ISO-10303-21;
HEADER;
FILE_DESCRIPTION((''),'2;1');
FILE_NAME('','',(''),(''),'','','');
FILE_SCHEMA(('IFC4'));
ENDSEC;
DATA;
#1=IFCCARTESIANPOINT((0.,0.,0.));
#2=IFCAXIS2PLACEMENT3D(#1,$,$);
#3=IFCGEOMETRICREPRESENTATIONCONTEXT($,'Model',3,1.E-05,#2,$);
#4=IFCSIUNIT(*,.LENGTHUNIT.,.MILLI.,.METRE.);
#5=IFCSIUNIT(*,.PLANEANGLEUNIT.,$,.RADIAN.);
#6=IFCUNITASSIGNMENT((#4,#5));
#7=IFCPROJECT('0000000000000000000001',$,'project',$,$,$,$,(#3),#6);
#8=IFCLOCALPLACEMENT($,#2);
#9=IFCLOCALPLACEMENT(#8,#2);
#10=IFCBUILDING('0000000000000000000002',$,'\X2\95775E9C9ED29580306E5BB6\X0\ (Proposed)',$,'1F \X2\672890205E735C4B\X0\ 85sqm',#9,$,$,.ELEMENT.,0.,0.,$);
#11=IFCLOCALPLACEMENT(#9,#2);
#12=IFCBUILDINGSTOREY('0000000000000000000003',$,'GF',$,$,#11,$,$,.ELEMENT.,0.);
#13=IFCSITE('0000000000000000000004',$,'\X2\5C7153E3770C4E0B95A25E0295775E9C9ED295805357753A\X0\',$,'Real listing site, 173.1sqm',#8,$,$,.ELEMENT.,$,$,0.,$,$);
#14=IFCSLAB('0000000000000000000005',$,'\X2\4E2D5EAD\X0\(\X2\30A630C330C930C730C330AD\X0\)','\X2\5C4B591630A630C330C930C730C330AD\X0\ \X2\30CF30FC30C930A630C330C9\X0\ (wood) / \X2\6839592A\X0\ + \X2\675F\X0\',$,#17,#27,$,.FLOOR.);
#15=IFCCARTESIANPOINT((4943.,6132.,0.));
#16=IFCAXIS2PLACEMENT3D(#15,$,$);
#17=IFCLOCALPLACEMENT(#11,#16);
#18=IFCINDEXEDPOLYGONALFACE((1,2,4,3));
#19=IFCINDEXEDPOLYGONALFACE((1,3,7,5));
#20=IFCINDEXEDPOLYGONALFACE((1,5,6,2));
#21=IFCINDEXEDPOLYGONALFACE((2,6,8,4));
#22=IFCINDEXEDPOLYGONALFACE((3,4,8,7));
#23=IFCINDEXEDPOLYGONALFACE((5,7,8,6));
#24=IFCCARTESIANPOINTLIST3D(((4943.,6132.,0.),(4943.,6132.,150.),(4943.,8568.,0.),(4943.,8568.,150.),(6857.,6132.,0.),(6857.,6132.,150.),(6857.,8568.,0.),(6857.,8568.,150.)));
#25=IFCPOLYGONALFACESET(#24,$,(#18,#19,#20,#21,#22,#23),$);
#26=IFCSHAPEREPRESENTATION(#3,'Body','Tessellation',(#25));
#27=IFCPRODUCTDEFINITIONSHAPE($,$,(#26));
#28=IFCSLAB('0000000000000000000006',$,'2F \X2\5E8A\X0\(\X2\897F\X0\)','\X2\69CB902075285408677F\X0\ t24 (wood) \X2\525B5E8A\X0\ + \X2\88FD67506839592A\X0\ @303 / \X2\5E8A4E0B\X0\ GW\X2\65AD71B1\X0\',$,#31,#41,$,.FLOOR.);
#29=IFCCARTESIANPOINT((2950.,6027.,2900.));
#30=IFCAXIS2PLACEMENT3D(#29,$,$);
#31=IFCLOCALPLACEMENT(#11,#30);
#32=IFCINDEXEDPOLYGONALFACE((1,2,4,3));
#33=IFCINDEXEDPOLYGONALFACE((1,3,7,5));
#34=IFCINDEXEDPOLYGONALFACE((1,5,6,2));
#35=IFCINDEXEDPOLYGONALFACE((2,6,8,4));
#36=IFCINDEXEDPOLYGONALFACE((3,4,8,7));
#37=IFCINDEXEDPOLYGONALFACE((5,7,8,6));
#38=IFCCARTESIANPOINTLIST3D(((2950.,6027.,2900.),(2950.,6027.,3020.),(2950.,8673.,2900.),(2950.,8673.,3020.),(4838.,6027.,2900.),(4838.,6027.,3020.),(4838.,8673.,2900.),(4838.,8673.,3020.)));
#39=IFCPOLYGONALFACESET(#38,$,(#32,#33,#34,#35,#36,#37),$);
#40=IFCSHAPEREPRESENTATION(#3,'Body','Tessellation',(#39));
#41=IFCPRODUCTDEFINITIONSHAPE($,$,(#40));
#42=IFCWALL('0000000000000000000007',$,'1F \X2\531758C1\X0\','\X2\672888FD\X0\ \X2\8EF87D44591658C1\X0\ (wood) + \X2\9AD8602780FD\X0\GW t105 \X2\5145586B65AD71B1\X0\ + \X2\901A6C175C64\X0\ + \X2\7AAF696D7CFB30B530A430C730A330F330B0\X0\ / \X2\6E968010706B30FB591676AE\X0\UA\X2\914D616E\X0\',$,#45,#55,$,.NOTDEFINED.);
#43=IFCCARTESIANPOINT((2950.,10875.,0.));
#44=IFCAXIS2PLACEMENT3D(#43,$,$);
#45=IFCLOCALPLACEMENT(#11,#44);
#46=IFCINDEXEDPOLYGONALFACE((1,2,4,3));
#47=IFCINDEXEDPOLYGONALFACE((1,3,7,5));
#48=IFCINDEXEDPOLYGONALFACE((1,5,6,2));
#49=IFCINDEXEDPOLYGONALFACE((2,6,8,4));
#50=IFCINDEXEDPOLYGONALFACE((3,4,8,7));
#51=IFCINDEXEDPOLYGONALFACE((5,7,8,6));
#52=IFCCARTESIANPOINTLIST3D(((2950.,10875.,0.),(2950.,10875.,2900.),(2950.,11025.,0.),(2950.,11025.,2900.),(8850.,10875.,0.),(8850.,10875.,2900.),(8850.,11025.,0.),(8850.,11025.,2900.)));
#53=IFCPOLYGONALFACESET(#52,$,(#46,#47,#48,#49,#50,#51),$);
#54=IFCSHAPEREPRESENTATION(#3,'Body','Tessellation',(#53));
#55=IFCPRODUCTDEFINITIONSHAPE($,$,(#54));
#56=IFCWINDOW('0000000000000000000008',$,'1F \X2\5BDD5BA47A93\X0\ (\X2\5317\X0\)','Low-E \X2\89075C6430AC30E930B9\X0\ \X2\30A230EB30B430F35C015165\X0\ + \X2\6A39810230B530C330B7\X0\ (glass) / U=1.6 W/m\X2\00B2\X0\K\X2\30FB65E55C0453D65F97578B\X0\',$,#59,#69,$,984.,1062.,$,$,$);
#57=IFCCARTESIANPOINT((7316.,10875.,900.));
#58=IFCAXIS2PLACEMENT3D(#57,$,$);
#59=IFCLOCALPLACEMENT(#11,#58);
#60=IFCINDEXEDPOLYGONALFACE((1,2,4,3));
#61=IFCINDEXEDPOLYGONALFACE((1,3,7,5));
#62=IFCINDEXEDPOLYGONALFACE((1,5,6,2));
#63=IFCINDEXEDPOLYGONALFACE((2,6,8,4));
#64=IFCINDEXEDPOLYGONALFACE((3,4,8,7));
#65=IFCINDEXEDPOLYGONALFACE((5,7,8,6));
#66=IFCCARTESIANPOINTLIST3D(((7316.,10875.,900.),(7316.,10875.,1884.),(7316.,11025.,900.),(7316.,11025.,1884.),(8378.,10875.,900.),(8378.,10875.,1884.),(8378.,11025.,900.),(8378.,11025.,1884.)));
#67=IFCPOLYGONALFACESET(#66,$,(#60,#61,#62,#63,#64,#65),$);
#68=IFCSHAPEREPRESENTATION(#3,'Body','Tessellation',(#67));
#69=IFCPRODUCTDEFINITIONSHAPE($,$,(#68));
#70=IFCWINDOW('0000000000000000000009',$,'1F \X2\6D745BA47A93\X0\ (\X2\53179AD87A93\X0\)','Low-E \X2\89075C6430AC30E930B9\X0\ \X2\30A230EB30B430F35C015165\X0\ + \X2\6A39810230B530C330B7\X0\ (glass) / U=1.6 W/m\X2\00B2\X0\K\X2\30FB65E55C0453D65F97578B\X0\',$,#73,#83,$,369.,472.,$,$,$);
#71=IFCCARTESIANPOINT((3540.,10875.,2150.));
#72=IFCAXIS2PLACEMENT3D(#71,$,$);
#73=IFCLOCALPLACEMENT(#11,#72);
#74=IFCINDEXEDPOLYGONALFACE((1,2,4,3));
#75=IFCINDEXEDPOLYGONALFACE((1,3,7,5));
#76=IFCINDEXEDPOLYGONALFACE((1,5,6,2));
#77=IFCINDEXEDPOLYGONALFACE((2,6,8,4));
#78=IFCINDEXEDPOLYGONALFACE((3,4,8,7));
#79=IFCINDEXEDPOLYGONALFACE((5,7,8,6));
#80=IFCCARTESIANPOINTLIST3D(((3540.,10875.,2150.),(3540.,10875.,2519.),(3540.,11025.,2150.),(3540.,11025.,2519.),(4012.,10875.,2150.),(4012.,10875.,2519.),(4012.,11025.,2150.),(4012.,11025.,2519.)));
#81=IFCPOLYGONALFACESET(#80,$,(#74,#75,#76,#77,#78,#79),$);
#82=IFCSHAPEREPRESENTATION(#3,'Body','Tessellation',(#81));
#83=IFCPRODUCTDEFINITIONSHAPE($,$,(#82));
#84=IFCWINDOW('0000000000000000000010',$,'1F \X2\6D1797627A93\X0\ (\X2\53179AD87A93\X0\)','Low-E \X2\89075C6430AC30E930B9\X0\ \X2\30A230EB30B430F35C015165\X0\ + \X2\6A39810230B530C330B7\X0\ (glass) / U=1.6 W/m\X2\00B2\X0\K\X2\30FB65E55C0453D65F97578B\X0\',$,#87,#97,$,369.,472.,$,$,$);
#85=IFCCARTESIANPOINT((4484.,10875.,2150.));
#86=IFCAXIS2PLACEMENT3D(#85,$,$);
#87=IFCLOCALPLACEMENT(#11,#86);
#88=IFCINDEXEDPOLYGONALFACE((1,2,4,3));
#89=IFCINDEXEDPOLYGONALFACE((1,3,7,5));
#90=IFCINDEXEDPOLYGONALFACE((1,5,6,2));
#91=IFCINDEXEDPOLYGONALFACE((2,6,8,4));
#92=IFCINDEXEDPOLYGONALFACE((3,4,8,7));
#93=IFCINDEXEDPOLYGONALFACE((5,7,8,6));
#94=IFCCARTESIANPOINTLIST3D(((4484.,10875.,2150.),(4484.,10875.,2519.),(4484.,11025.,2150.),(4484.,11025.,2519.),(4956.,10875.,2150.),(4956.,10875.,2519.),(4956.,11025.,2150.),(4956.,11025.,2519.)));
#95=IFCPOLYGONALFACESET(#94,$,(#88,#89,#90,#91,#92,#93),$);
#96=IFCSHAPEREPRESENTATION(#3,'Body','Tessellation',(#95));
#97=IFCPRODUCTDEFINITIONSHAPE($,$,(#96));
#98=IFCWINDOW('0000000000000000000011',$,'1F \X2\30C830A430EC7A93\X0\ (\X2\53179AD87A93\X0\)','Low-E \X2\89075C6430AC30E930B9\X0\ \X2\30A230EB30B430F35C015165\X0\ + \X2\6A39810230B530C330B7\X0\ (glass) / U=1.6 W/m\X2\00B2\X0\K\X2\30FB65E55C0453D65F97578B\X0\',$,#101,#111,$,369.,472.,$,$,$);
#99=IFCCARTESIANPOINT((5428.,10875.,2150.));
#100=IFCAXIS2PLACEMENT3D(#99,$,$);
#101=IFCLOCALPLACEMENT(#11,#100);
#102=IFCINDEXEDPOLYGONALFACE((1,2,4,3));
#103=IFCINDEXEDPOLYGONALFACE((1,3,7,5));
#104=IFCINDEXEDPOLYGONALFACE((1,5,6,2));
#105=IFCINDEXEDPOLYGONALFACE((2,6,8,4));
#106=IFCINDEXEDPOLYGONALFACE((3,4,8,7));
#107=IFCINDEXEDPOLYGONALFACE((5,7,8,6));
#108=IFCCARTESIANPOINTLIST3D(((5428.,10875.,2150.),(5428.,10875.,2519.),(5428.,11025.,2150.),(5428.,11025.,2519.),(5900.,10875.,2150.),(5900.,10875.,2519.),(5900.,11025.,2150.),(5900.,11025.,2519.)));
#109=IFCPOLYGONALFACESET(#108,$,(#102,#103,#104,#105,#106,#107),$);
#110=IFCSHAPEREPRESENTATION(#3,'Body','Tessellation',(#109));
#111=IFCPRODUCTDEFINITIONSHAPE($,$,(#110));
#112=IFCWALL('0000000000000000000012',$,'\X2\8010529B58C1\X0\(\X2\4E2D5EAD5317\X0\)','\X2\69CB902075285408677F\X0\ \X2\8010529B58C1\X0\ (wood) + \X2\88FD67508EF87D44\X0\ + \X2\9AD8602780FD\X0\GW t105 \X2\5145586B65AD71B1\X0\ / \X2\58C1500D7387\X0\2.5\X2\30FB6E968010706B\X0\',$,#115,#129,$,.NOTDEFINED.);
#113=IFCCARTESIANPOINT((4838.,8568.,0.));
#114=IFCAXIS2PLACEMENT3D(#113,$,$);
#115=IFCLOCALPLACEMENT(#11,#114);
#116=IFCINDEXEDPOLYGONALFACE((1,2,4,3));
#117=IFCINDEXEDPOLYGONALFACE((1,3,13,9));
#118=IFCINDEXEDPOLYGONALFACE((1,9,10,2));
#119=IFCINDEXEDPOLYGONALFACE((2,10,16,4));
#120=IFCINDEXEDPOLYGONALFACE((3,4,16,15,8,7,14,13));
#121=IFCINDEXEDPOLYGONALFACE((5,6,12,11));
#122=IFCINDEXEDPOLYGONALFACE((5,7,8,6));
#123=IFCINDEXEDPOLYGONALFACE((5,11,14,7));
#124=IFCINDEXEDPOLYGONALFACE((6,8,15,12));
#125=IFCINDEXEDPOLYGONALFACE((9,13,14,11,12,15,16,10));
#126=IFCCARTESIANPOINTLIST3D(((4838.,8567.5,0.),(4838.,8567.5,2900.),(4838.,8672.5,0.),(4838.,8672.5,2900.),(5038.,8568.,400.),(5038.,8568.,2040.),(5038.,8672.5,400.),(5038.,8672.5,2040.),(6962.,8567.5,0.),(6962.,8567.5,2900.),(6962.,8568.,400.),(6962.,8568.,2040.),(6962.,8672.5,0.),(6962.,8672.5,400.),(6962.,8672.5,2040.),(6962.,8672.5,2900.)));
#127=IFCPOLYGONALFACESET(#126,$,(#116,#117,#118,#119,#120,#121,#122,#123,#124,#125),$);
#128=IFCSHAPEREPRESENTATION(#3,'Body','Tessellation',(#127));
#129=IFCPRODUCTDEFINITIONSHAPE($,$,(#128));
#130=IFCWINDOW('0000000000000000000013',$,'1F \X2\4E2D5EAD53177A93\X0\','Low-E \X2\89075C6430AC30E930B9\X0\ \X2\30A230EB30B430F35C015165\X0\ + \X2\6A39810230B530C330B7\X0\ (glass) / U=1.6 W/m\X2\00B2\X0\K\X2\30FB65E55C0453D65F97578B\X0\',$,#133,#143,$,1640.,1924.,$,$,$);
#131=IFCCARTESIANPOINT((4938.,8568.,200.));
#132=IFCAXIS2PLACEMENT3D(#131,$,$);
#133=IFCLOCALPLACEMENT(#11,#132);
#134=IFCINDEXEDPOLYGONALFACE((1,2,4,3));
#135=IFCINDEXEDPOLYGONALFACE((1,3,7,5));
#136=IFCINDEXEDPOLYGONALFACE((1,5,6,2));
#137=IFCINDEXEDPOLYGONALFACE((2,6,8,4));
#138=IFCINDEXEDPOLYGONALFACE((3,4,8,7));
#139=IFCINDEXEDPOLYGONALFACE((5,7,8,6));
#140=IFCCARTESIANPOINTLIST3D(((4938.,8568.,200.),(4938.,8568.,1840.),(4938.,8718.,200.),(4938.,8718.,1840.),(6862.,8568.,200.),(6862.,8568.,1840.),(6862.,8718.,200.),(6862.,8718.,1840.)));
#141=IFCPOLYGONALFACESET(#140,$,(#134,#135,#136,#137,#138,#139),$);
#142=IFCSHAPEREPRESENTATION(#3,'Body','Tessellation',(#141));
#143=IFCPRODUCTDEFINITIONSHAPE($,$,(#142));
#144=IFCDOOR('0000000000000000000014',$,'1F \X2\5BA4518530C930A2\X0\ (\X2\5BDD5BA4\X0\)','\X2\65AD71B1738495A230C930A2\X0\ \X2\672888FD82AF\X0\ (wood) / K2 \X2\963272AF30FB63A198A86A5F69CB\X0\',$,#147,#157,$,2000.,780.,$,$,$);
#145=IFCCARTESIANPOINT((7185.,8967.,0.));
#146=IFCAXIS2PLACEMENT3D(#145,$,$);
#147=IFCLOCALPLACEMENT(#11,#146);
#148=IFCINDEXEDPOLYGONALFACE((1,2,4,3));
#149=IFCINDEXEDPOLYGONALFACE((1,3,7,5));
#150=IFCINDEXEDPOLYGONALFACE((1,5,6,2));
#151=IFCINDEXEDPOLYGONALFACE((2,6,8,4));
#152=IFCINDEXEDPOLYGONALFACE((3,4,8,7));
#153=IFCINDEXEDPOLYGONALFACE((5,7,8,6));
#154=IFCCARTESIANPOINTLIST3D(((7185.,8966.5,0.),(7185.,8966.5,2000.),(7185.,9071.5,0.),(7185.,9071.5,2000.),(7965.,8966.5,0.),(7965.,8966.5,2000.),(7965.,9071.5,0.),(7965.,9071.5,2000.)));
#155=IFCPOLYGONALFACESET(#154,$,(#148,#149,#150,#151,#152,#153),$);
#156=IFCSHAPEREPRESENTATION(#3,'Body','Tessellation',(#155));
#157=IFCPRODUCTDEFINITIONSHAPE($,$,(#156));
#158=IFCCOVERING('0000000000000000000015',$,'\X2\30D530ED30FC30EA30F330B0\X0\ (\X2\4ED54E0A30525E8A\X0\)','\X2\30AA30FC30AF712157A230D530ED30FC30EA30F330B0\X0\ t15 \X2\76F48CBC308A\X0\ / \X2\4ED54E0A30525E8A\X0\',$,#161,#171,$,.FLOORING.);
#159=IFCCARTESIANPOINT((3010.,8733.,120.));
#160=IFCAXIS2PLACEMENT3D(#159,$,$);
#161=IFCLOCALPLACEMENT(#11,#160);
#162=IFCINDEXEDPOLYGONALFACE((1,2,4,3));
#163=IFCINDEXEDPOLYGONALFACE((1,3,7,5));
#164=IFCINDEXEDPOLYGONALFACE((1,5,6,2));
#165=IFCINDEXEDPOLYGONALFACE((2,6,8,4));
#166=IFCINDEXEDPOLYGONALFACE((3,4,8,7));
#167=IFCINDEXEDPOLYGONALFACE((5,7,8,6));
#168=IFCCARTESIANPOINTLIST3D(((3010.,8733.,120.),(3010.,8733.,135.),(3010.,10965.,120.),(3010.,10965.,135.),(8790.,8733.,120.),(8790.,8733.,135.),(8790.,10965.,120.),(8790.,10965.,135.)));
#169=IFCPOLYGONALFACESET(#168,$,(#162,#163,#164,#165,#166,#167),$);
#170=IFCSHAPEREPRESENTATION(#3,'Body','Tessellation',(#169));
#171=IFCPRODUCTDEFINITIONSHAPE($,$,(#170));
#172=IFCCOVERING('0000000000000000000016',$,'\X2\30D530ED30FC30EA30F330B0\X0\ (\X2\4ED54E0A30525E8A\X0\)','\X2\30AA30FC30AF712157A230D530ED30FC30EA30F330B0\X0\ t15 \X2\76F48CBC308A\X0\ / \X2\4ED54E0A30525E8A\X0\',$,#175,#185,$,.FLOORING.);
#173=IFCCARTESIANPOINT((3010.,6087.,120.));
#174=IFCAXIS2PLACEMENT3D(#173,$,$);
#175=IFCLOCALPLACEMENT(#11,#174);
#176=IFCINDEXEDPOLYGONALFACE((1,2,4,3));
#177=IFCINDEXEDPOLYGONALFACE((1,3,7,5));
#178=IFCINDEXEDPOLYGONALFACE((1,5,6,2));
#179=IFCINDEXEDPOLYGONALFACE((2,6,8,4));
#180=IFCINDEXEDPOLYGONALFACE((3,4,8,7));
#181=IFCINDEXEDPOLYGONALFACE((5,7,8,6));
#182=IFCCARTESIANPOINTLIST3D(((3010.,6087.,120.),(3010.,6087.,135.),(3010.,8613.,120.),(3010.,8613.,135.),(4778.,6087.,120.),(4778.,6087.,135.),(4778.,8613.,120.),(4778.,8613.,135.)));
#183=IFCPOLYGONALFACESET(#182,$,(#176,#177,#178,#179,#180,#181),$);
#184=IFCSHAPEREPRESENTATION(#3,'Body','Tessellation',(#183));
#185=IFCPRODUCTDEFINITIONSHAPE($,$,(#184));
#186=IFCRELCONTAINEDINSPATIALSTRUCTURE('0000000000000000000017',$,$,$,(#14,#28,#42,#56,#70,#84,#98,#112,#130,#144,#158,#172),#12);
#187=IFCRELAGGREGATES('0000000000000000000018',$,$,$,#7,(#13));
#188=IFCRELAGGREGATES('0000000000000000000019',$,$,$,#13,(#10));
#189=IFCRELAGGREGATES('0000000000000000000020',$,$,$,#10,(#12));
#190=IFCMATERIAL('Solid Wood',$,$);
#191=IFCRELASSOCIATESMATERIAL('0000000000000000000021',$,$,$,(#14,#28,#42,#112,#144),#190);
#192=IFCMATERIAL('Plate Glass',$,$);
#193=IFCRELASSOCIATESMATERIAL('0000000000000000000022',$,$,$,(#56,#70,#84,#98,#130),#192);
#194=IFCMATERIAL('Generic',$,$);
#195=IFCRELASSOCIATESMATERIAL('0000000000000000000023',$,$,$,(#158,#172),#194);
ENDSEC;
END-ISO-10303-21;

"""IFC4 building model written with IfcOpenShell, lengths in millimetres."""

from ifc_helpers import new_model, si_unit, frame, frame_2d, origin, place, context, project, spatial, rectangle, extrude, material, element, fill, save


model = new_model("IFC4")

# Units and contexts
model_context = context("Model", 3, precision=1e-05, world=origin())
ifc_project = project(units=[si_unit("LENGTHUNIT", "METRE", prefix="MILLI"), si_unit("PLANEANGLEUNIT", "RADIAN")], contexts=[model_context])

# Site, building, storey
site_placement = place(None, origin())
site = spatial("IfcSite", under=ifc_project, at=site_placement, Name="山口県下関市長府黒門南町", ObjectType="Real listing site, 173.1sqm", CompositionType="ELEMENT", RefElevation=0.0)
building_placement = place(site_placement, origin())
building = spatial("IfcBuilding", under=site, at=building_placement, Name="長府黒門の家 (Proposed)", ObjectType="1F 木造平屋 85sqm", CompositionType="ELEMENT", ElevationOfRefHeight=0.0, ElevationOfTerrain=0.0)
storey_placement = place(building_placement, origin())
storey = spatial("IfcBuildingStorey", under=building, at=storey_placement, Name="GF", CompositionType="ELEMENT", Elevation=0.0)

# Slabs
ifc_material_1 = material(Name="Solid Wood")
slab_1_placement = place(storey_placement, frame((4943.0, 6132.0, 0.0)))
element("IfcSlab", 1, at=slab_1_placement, inside=storey, material=ifc_material_1, Name="中庭(ウッドデッキ)", Description="屋外ウッドデッキ ハードウッド (wood) / 根太 + 束", PredefinedType="FLOOR", context=model_context, shape_type="SweptSolid", body=[
    extrude(rectangle(XDim=1914.0, YDim=2436.0, at=frame_2d((957.0, 1218.0))), frame((4943.0, 6132.0, 0.0)), (0.0, 0.0, 1.0), 150.0),
])
slab_2_placement = place(storey_placement, frame((2950.0, 6027.0, 2900.0)))
element("IfcSlab", 2, at=slab_2_placement, inside=storey, material=ifc_material_1, Name="2F 床(西)", Description="構造用合板 t24 (wood) 剛床 + 製材根太 @303 / 床下 GW断熱", PredefinedType="FLOOR", context=model_context, shape_type="SweptSolid", body=[
    extrude(rectangle(XDim=1888.0, YDim=2646.0, at=frame_2d((944.0, 1323.0))), frame((2950.0, 6027.0, 2900.0)), (0.0, 0.0, 1.0), 120.0),
])

# Wall, openings, windows
wall_1_placement = place(storey_placement, frame((2950.0, 10875.0, 0.0)))
wall_1 = element("IfcWall", 3, at=wall_1_placement, inside=storey, material=ifc_material_1, Name="1F 北壁", Description="木製 軸組外壁 (wood) + 高性能GW t105 充填断熱 + 通気層 + 窯業系サイディング / 準耐火・外皮UA配慮", PredefinedType="NOTDEFINED", context=model_context, shape_type="SweptSolid", body=[
    extrude(rectangle(XDim=5900.0, YDim=150.0, at=frame_2d((2950.0, 75.0))), frame((2950.0, 10875.0, 0.0)), (0.0, 0.0, 1.0), 2900.0),
])
opening_1_placement = place(storey_placement, frame((7316.0, 10875.0, 900.0)))
opening_1 = element("IfcOpeningElement", 4, at=opening_1_placement, cuts=wall_1, PredefinedType="NOTDEFINED", context=model_context, shape_type="SweptSolid", body=[
    extrude(rectangle(XDim=1062.0, YDim=150.0, at=frame_2d((531.0, 75.0))), frame((7316.0, 10875.0, 900.0)), (0.0, 0.0, 1.0), 984.0),
])
opening_2_placement = place(storey_placement, frame((3540.0, 10875.0, 2150.0)))
opening_2 = element("IfcOpeningElement", 5, at=opening_2_placement, cuts=wall_1, PredefinedType="NOTDEFINED", context=model_context, shape_type="SweptSolid", body=[
    extrude(rectangle(XDim=472.0, YDim=150.0, at=frame_2d((236.0, 75.0))), frame((3540.0, 10875.0, 2150.0)), (0.0, 0.0, 1.0), 369.0),
])
opening_3_placement = place(storey_placement, frame((4484.0, 10875.0, 2150.0)))
opening_3 = element("IfcOpeningElement", 6, at=opening_3_placement, cuts=wall_1, PredefinedType="NOTDEFINED", context=model_context, shape_type="SweptSolid", body=[
    extrude(rectangle(XDim=472.0, YDim=150.0, at=frame_2d((236.0, 75.0))), frame((4484.0, 10875.0, 2150.0)), (0.0, 0.0, 1.0), 369.0),
])
opening_4_placement = place(storey_placement, frame((5428.0, 10875.0, 2150.0)))
opening_4 = element("IfcOpeningElement", 7, at=opening_4_placement, cuts=wall_1, PredefinedType="NOTDEFINED", context=model_context, shape_type="SweptSolid", body=[
    extrude(rectangle(XDim=472.0, YDim=150.0, at=frame_2d((236.0, 75.0))), frame((5428.0, 10875.0, 2150.0)), (0.0, 0.0, 1.0), 369.0),
])
ifc_material_2 = material(Name="Plate Glass")
window_1_placement = place(storey_placement, frame((7316.0, 10875.0, 900.0)))
window_1 = element("IfcWindow", 8, at=window_1_placement, inside=storey, material=ifc_material_2, Name="1F 寝室窓 (北)", Description="Low-E 複層ガラス アルゴン封入 + 樹脂サッシ (glass) / U=1.6 W/m²K・日射取得型", OverallHeight=984.0, OverallWidth=1062.0, context=model_context, shape_type="SweptSolid", body=[
    extrude(rectangle(XDim=1062.0, YDim=150.0, at=frame_2d((531.0, 75.0))), frame((7316.0, 10875.0, 900.0)), (0.0, 0.0, 1.0), 984.0),
])
fill(opening_1, window_1)
window_2_placement = place(storey_placement, frame((3540.0, 10875.0, 2150.0)))
window_2 = element("IfcWindow", 9, at=window_2_placement, inside=storey, material=ifc_material_2, Name="1F 浴室窓 (北高窓)", Description="Low-E 複層ガラス アルゴン封入 + 樹脂サッシ (glass) / U=1.6 W/m²K・日射取得型", OverallHeight=369.0, OverallWidth=472.0, context=model_context, shape_type="SweptSolid", body=[
    extrude(rectangle(XDim=472.0, YDim=150.0, at=frame_2d((236.0, 75.0))), frame((3540.0, 10875.0, 2150.0)), (0.0, 0.0, 1.0), 369.0),
])
fill(opening_2, window_2)
window_3_placement = place(storey_placement, frame((4484.0, 10875.0, 2150.0)))
window_3 = element("IfcWindow", 10, at=window_3_placement, inside=storey, material=ifc_material_2, Name="1F 洗面窓 (北高窓)", Description="Low-E 複層ガラス アルゴン封入 + 樹脂サッシ (glass) / U=1.6 W/m²K・日射取得型", OverallHeight=369.0, OverallWidth=472.0, context=model_context, shape_type="SweptSolid", body=[
    extrude(rectangle(XDim=472.0, YDim=150.0, at=frame_2d((236.0, 75.0))), frame((4484.0, 10875.0, 2150.0)), (0.0, 0.0, 1.0), 369.0),
])
fill(opening_3, window_3)
window_4_placement = place(storey_placement, frame((5428.0, 10875.0, 2150.0)))
window_4 = element("IfcWindow", 11, at=window_4_placement, inside=storey, material=ifc_material_2, Name="1F トイレ窓 (北高窓)", Description="Low-E 複層ガラス アルゴン封入 + 樹脂サッシ (glass) / U=1.6 W/m²K・日射取得型", OverallHeight=369.0, OverallWidth=472.0, context=model_context, shape_type="SweptSolid", body=[
    extrude(rectangle(XDim=472.0, YDim=150.0, at=frame_2d((236.0, 75.0))), frame((5428.0, 10875.0, 2150.0)), (0.0, 0.0, 1.0), 369.0),
])
fill(opening_4, window_4)

# Wall, opening, window
wall_2_placement = place(storey_placement, frame((4838.0, 8568.0, 0.0)))
wall_2 = element("IfcWall", 12, at=wall_2_placement, inside=storey, material=ifc_material_1, Name="耐力壁(中庭北)", Description="構造用合板 耐力壁 (wood) + 製材軸組 + 高性能GW t105 充填断熱 / 壁倍率2.5・準耐火", PredefinedType="NOTDEFINED", context=model_context, shape_type="SweptSolid", body=[
    extrude(rectangle(XDim=2124.0, YDim=105.0, at=frame_2d((1062.0, 52.0))), frame((4838.0, 8568.0, 0.0)), (0.0, 0.0, 1.0), 2900.0),
])
opening_5_placement = place(storey_placement, frame((4938.0, 8568.0, 200.0)))
opening_5 = element("IfcOpeningElement", 13, at=opening_5_placement, cuts=wall_2, PredefinedType="NOTDEFINED", context=model_context, shape_type="SweptSolid", body=[
    extrude(rectangle(XDim=1924.0, YDim=150.0, at=frame_2d((962.0, 75.0))), frame((4938.0, 8568.0, 200.0)), (0.0, 0.0, 1.0), 1640.0),
])
window_5_placement = place(storey_placement, frame((4938.0, 8568.0, 200.0)))
window_5 = element("IfcWindow", 14, at=window_5_placement, inside=storey, material=ifc_material_2, Name="1F 中庭北窓", Description="Low-E 複層ガラス アルゴン封入 + 樹脂サッシ (glass) / U=1.6 W/m²K・日射取得型", OverallHeight=1640.0, OverallWidth=1924.0, context=model_context, shape_type="SweptSolid", body=[
    extrude(rectangle(XDim=1924.0, YDim=150.0, at=frame_2d((962.0, 75.0))), frame((4938.0, 8568.0, 200.0)), (0.0, 0.0, 1.0), 1640.0),
])
fill(opening_5, window_5)

# Door
door_1_placement = place(storey_placement, frame((7185.0, 8967.0, 0.0)))
element("IfcDoor", 15, at=door_1_placement, inside=storey, material=ifc_material_1, Name="1F 室内ドア (寝室)", Description="断熱玄関ドア 木製芯 (wood) / K2 防犯・採風機構", OverallHeight=2000.0, OverallWidth=780.0, context=model_context, shape_type="SweptSolid", body=[
    extrude(rectangle(XDim=780.0, YDim=105.0, at=frame_2d((390.0, 52.0))), frame((7185.0, 8967.0, 0.0)), (0.0, 0.0, 1.0), 2000.0),
])

# Coverings
ifc_material_3 = material(Name="Generic")
covering_1_placement = place(storey_placement, frame((3010.0, 8733.0, 120.0)))
element("IfcCovering", 16, at=covering_1_placement, inside=storey, material=ifc_material_3, Name="フローリング (仕上げ床)", Description="オーク無垢フローリング t15 直貼り / 仕上げ床", PredefinedType="FLOORING", context=model_context, shape_type="SweptSolid", body=[
    extrude(rectangle(XDim=5780.0, YDim=2232.0, at=frame_2d((2890.0, 1116.0))), frame((3010.0, 8733.0, 120.0)), (0.0, 0.0, 1.0), 15.0),
])
covering_2_placement = place(storey_placement, frame((3010.0, 6087.0, 120.0)))
element("IfcCovering", 17, at=covering_2_placement, inside=storey, material=ifc_material_3, Name="フローリング (仕上げ床)", Description="オーク無垢フローリング t15 直貼り / 仕上げ床", PredefinedType="FLOORING", context=model_context, shape_type="SweptSolid", body=[
    extrude(rectangle(XDim=1768.0, YDim=2526.0, at=frame_2d((884.0, 1263.0))), frame((3010.0, 6087.0, 120.0)), (0.0, 0.0, 1.0), 15.0),
])

save(model, "model.ifc")
